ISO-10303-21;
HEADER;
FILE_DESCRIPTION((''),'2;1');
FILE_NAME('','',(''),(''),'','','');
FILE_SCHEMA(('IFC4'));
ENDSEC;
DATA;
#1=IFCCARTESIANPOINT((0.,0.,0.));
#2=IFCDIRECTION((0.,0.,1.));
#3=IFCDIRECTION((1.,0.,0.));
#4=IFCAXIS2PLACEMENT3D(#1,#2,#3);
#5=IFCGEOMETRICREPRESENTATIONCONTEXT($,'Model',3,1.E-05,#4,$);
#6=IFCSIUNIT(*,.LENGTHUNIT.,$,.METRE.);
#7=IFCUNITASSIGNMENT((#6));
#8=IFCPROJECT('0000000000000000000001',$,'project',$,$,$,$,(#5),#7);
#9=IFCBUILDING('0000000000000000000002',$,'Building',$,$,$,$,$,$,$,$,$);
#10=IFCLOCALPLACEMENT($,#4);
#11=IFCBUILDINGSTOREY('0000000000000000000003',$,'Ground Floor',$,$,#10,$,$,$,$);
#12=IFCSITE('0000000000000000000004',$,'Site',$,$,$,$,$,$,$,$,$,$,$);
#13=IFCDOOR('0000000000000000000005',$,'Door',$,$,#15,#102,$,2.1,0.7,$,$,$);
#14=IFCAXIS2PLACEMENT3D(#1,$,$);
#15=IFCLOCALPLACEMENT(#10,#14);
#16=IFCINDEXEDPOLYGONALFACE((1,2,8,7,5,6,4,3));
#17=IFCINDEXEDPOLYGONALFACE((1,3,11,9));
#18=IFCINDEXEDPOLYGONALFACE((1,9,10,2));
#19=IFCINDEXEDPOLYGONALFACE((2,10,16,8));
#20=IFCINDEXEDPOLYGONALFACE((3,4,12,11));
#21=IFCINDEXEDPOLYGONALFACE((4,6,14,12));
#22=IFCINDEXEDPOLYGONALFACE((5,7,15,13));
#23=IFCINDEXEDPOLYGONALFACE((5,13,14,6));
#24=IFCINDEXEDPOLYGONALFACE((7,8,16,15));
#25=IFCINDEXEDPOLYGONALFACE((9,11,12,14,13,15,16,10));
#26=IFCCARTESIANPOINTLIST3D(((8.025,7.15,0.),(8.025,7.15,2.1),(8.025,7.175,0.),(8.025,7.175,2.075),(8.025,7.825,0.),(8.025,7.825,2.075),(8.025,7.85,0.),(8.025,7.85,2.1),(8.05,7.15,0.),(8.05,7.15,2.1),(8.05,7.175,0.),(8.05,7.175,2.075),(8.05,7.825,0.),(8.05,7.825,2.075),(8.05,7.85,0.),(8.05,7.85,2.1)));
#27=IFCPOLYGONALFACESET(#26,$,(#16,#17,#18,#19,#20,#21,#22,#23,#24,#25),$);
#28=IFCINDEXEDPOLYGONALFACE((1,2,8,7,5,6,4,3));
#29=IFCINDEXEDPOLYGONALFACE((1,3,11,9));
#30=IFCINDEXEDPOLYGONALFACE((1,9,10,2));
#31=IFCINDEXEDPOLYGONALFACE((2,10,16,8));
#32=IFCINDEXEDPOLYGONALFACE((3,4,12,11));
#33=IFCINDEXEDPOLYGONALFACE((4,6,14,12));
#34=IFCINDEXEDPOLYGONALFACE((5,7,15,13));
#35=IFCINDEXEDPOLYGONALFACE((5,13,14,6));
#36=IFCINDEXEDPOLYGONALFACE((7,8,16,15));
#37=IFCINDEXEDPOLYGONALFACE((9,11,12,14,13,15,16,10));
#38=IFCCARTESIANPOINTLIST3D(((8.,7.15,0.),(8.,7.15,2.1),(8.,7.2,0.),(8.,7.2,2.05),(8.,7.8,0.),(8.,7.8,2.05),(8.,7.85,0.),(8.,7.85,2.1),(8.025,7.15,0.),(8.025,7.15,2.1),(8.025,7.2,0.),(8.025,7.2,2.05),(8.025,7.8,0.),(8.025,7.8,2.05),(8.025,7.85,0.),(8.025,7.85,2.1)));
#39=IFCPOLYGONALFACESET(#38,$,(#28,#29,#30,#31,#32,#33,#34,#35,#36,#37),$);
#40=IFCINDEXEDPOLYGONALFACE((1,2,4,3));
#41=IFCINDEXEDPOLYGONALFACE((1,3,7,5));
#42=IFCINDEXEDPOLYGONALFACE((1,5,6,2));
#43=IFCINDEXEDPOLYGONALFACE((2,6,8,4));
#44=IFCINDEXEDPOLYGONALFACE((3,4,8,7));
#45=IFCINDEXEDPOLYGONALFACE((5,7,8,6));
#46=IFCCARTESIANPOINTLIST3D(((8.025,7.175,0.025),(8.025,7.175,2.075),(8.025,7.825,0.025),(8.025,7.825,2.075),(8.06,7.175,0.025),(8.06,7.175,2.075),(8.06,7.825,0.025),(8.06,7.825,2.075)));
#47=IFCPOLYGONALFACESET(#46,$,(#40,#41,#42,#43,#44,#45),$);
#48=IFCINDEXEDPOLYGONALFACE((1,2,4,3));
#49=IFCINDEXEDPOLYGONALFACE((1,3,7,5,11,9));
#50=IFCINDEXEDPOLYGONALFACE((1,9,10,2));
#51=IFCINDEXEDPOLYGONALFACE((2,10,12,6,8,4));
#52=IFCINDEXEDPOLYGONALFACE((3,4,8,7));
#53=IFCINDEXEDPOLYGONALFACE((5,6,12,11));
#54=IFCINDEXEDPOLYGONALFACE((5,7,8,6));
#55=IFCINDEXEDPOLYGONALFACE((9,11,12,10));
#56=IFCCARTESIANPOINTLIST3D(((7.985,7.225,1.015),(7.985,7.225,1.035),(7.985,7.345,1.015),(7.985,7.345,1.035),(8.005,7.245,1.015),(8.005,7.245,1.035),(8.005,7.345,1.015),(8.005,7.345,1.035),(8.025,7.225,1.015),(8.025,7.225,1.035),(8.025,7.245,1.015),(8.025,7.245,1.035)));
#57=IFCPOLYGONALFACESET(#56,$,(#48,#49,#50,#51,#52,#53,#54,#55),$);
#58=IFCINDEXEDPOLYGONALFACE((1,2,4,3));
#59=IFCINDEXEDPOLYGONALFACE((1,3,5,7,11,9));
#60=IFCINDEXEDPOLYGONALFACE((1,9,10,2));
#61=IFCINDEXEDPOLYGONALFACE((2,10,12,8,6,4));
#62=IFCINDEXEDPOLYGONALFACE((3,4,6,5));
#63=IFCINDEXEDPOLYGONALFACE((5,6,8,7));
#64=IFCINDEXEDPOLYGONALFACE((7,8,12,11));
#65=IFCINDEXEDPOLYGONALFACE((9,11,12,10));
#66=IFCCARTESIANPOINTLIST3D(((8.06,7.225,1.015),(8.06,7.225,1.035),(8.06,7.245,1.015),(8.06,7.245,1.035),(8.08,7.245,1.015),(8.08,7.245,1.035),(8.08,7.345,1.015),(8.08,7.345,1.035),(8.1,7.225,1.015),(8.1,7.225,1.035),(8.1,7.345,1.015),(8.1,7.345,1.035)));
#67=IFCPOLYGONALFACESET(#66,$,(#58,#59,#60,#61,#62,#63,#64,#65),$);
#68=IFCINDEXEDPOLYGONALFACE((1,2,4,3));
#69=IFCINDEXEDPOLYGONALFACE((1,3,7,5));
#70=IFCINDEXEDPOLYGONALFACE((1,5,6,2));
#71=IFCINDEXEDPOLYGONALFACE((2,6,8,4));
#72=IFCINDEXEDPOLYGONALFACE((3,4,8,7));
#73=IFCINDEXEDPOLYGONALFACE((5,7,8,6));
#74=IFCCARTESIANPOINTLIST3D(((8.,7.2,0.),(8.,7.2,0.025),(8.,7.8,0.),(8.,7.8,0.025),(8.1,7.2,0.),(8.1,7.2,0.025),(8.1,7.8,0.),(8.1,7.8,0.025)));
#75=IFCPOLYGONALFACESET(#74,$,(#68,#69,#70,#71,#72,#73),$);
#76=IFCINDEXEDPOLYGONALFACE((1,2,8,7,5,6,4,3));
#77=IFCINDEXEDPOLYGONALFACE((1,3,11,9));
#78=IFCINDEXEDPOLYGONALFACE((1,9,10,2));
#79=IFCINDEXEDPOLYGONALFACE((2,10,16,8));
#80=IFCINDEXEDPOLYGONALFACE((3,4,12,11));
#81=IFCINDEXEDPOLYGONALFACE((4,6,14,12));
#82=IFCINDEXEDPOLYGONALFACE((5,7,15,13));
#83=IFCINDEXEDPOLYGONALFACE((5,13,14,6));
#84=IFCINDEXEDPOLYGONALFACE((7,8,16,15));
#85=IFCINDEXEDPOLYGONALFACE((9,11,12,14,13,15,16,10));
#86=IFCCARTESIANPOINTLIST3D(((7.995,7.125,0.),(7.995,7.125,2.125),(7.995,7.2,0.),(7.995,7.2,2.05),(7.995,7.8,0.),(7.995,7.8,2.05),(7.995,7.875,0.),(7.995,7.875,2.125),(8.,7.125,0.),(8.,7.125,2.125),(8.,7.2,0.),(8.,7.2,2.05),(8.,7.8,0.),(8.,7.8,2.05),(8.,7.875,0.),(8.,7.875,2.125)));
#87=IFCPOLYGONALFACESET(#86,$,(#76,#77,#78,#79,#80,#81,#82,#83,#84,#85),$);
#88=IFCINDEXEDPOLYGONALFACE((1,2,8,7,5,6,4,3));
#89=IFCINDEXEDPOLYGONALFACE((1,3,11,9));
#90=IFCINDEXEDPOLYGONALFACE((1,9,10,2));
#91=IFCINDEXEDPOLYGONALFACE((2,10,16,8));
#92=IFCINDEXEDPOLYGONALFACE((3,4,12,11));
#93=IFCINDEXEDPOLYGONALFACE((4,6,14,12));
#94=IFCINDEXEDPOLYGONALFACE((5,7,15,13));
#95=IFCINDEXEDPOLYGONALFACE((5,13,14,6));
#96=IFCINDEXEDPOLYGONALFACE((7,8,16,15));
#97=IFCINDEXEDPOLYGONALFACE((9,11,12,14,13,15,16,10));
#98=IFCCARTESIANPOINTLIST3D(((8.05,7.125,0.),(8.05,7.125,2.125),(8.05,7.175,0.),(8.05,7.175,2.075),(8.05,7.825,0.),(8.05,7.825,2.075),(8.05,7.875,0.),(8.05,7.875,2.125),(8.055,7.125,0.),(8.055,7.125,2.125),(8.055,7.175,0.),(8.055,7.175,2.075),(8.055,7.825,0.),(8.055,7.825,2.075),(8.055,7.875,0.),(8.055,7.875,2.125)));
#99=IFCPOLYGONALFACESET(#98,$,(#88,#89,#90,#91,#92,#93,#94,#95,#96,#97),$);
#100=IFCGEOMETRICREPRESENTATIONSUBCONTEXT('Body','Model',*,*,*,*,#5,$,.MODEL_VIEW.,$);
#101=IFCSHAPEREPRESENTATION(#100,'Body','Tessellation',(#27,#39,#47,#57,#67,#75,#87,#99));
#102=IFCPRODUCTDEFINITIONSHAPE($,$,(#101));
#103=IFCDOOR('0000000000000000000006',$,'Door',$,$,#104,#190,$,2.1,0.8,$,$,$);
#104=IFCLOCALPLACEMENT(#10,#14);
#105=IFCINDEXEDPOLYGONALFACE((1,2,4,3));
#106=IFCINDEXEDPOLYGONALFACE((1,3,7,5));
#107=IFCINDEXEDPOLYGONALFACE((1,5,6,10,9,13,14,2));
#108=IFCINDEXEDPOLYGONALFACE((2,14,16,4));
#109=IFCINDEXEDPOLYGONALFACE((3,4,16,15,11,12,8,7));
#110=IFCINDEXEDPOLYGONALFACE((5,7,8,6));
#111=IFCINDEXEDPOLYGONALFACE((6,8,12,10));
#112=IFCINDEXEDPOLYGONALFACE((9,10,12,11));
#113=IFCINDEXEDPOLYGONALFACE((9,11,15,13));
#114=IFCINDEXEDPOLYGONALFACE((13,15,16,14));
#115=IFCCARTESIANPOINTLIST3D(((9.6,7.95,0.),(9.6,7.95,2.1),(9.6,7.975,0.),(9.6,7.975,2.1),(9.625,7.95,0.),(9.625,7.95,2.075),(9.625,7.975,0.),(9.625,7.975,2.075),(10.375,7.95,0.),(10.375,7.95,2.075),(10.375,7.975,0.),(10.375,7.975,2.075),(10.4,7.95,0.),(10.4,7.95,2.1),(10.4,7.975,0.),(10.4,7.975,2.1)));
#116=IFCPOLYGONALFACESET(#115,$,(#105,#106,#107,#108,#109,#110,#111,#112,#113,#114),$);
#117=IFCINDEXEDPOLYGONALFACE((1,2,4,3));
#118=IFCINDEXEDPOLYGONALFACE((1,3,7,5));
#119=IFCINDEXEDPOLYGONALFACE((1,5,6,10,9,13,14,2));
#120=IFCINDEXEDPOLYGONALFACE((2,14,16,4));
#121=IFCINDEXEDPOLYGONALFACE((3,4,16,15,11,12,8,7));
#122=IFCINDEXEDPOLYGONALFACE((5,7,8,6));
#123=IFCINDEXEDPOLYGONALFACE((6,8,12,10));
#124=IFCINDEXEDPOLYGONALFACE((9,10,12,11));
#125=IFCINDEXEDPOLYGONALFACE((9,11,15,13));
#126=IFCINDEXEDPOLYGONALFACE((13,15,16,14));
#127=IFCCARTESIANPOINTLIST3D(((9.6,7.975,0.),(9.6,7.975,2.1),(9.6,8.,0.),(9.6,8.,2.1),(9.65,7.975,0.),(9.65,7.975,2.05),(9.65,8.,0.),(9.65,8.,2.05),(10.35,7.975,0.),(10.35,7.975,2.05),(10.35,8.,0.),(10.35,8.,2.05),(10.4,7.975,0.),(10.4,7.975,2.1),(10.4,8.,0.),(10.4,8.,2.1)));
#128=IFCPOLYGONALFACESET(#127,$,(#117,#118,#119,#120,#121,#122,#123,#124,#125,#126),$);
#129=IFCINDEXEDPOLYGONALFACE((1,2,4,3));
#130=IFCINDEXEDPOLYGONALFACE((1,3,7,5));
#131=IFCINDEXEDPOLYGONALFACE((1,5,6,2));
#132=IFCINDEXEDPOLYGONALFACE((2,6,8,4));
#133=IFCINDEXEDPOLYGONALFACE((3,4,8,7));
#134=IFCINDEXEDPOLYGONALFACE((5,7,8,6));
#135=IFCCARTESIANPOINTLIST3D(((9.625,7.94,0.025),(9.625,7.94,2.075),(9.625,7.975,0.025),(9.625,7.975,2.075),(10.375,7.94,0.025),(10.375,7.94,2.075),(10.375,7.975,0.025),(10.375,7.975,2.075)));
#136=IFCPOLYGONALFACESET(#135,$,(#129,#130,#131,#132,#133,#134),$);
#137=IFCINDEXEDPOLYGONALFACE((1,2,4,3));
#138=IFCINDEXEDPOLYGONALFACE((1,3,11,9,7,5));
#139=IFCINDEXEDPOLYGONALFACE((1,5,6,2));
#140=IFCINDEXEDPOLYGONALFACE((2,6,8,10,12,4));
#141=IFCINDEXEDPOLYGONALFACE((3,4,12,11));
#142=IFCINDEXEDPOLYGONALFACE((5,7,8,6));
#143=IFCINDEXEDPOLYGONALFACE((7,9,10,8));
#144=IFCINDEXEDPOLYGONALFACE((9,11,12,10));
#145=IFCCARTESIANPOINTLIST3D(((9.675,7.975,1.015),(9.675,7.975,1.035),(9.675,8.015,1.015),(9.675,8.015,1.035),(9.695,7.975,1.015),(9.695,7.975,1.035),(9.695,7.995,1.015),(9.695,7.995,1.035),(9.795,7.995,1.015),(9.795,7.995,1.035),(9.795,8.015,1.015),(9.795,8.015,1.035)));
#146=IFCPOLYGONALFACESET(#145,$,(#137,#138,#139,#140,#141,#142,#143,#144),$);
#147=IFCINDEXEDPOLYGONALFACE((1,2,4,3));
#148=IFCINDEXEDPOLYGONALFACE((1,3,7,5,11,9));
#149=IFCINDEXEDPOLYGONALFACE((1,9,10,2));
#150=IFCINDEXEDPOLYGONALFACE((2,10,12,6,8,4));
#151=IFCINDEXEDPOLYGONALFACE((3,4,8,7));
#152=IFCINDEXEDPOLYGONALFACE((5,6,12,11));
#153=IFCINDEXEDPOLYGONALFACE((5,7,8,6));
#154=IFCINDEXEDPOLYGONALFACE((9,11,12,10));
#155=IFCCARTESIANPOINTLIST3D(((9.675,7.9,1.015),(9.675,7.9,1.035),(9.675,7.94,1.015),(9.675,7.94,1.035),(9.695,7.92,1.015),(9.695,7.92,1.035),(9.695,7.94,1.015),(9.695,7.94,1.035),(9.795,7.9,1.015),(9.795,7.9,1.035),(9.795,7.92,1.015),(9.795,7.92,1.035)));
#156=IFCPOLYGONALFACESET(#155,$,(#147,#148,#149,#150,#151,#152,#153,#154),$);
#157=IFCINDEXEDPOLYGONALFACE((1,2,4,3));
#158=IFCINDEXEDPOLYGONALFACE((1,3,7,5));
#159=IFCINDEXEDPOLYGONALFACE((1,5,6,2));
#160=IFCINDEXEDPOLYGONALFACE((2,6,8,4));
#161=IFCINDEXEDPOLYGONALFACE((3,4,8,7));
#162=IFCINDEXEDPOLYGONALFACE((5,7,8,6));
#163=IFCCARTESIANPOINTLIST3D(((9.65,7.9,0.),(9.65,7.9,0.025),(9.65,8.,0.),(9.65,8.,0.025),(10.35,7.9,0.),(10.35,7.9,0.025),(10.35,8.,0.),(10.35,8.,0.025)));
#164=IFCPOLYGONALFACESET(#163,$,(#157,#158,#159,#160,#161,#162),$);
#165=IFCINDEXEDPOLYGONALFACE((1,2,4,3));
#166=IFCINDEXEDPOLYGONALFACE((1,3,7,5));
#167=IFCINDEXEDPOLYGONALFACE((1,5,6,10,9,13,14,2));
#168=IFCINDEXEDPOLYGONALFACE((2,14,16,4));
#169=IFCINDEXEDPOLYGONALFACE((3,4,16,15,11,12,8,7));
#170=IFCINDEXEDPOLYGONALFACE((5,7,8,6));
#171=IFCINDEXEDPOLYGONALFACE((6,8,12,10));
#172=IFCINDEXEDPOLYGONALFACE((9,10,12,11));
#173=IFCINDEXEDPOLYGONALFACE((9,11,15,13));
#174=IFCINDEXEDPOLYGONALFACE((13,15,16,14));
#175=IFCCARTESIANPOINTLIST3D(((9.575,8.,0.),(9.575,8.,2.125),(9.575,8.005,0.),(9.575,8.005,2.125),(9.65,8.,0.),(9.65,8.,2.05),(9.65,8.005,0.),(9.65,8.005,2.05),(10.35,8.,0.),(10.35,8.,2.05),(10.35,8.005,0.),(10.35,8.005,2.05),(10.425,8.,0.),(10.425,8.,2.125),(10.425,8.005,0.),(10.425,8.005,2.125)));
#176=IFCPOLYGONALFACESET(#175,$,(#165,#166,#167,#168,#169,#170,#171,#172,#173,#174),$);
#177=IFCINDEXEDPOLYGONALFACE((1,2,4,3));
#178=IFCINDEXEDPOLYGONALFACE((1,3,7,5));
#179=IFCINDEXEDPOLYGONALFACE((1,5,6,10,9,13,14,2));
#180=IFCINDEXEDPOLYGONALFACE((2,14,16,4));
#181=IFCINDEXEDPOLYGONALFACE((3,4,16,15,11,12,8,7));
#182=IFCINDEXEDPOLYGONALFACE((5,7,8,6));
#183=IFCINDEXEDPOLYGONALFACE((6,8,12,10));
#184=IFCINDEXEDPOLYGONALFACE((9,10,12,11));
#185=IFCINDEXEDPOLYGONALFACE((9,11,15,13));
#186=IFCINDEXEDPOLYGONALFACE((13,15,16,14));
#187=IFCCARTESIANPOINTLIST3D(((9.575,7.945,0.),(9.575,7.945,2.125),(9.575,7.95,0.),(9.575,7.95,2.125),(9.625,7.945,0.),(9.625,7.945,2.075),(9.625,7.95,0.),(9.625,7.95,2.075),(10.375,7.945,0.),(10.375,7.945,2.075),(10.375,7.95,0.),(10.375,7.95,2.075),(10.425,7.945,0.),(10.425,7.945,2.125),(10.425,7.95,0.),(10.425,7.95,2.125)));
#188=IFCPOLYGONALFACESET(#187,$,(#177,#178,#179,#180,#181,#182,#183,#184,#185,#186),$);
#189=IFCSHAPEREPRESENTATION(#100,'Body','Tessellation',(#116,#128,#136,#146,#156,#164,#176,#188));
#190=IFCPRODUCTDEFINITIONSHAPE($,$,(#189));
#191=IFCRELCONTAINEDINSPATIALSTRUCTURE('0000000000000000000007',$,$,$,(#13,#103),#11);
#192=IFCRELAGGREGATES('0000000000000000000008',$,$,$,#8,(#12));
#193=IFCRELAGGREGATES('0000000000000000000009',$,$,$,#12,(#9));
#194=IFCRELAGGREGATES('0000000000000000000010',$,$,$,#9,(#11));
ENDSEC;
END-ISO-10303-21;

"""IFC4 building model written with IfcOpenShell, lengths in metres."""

from ifc_helpers import new_model, si_unit, frame, origin_with_axes, place, context, subcontext, project, spatial, line, indexed_curve, outline, extrude, element, save


model = new_model("IFC4")

# Units and contexts
model_context = context("Model", 3, precision=1e-05, world=origin_with_axes())
body_context = subcontext(model_context, "Body", "Model", "MODEL_VIEW")
ifc_project = project(units=[si_unit("LENGTHUNIT", "METRE")], contexts=[model_context])

# Site, building, storey
site = spatial("IfcSite", under=ifc_project, Name="Site")
building = spatial("IfcBuilding", under=site, Name="Building")
storey_placement = place(None, origin_with_axes())
storey = spatial("IfcBuildingStorey", under=building, at=storey_placement, Name="Ground Floor")

# Doors
door_1_placement = place(storey_placement, frame((8.0, 7.85, 0.0), z_axis=(0.0, 0.0, 1.0), x_axis=(0.0, -1.0, 0.0)))
element("IfcDoor", 1, at=door_1_placement, inside=storey, Name="Door", OverallHeight=2.1, OverallWidth=0.7, context=body_context, shape_type="SweptSolid", body=[
    extrude(outline(indexed_curve([(0.0, 0.0), (0.0, 2.1), (0.7, 2.1), (0.7, 0.0), (0.675, 0.0), (0.675, 2.075), (0.025, 2.075), (0.025, 0.0)], segments=[line(1, 2, 3, 4, 5, 6, 7, 8, 1)])), frame((0.0, 0.025, 0.0), z_axis=(0.0, -1.0, 0.0), x_axis=(1.0, 0.0, 0.0)), (0.0, 0.0, -1.0), 0.025),
    extrude(outline(indexed_curve([(0.0, 0.0), (0.0, 2.1), (0.7, 2.1), (0.7, 0.0), (0.65, 0.0), (0.65, 2.05), (0.05, 2.05), (0.05, 0.0)], segments=[line(1, 2, 3, 4, 5, 6, 7, 8, 1)])), frame((0.0, 0.0, 0.0), z_axis=(0.0, -1.0, 0.0), x_axis=(1.0, 0.0, 0.0)), (0.0, 0.0, -1.0), 0.025),
    extrude(outline(indexed_curve([(0.0, 0.0), (0.65, 0.0), (0.65, 0.035), (0.0, 0.035)], segments=[line(1, 2, 3, 4, 1)])), frame((0.025, 0.025, 0.025), z_axis=(0.0, 0.0, 1.0), x_axis=(1.0, 0.0, 0.0)), (0.0, 0.0, 1.0), 2.05),
    extrude(outline(indexed_curve([(0.0, 0.0), (0.0, -0.04), (-0.12, -0.04), (-0.12, -0.02), (-0.02, -0.02), (-0.02, 0.0)], segments=[line(1, 2, 3, 4, 5, 6, 1)])), frame((0.625, 0.025, 1.015), z_axis=(0.0, 0.0, 1.0), x_axis=(1.0, 0.0, 0.0)), (0.0, 0.0, 1.0), 0.02),
    extrude(outline(indexed_curve([(0.0, 0.0), (0.0, 0.04), (-0.12, 0.04), (-0.12, 0.02), (-0.02, 0.02), (-0.02, 0.0)], segments=[line(1, 2, 3, 4, 5, 6, 1)])), frame((0.625, 0.06, 1.015), z_axis=(0.0, 0.0, 1.0), x_axis=(1.0, 0.0, 0.0)), (0.0, 0.0, 1.0), 0.02),
    extrude(outline(indexed_curve([(0.0, 0.0), (0.6, 0.0), (0.6, 0.1), (0.0, 0.1)], segments=[line(1, 2, 3, 4, 1)])), frame((0.05, 0.0, 0.0), z_axis=(0.0, 0.0, 1.0), x_axis=(1.0, 0.0, 0.0)), (0.0, 0.0, 1.0), 0.025),
    extrude(outline(indexed_curve([(0.0, 0.0), (0.0, 2.125), (0.75, 2.125), (0.75, 0.0), (0.675, 0.0), (0.675, 2.05), (0.075, 2.05), (0.075, 0.0)], segments=[line(1, 2, 3, 4, 5, 6, 7, 8, 1)])), frame((-0.025, -0.005, 0.0), z_axis=(0.0, -1.0, 0.0), x_axis=(1.0, 0.0, 0.0)), (0.0, 0.0, -1.0), 0.005),
    extrude(outline(indexed_curve([(0.0, 0.0), (0.0, 2.125), (0.75, 2.125), (0.75, 0.0), (0.7, 0.0), (0.7, 2.075), (0.05, 2.075), (0.05, 0.0)], segments=[line(1, 2, 3, 4, 5, 6, 7, 8, 1)])), frame((-0.025, 0.05, 0.0), z_axis=(0.0, -1.0, 0.0), x_axis=(1.0, 0.0, 0.0)), (0.0, 0.0, -1.0), 0.005),
])
door_2_placement = place(storey_placement, frame((10.4, 8.0, 0.0), z_axis=(0.0, 0.0, 1.0), x_axis=(-1.0, 0.0, 0.0)))
element("IfcDoor", 2, at=door_2_placement, inside=storey, Name="Door", OverallHeight=2.1, OverallWidth=0.8, context=body_context, shape_type="SweptSolid", body=[
    extrude(outline(indexed_curve([(0.0, 0.0), (0.0, 2.1), (0.8, 2.1), (0.8, 0.0), (0.775, 0.0), (0.775, 2.075), (0.025, 2.075), (0.025, 0.0)], segments=[line(1, 2, 3, 4, 5, 6, 7, 8, 1)])), frame((0.0, 0.025, 0.0), z_axis=(0.0, -1.0, 0.0), x_axis=(1.0, 0.0, 0.0)), (0.0, 0.0, -1.0), 0.025),
    extrude(outline(indexed_curve([(0.0, 0.0), (0.0, 2.1), (0.8, 2.1), (0.8, 0.0), (0.75, 0.0), (0.75, 2.05), (0.05, 2.05), (0.05, 0.0)], segments=[line(1, 2, 3, 4, 5, 6, 7, 8, 1)])), frame((0.0, 0.0, 0.0), z_axis=(0.0, -1.0, 0.0), x_axis=(1.0, 0.0, 0.0)), (0.0, 0.0, -1.0), 0.025),
    extrude(outline(indexed_curve([(0.0, 0.0), (0.75, 0.0), (0.75, 0.035), (0.0, 0.035)], segments=[line(1, 2, 3, 4, 1)])), frame((0.025, 0.025, 0.025), z_axis=(0.0, 0.0, 1.0), x_axis=(1.0, 0.0, 0.0)), (0.0, 0.0, 1.0), 2.05),
    extrude(outline(indexed_curve([(0.0, 0.0), (0.0, -0.04), (-0.12, -0.04), (-0.12, -0.02), (-0.02, -0.02), (-0.02, 0.0)], segments=[line(1, 2, 3, 4, 5, 6, 1)])), frame((0.725, 0.025, 1.015), z_axis=(0.0, 0.0, 1.0), x_axis=(1.0, 0.0, 0.0)), (0.0, 0.0, 1.0), 0.02),
    extrude(outline(indexed_curve([(0.0, 0.0), (0.0, 0.04), (-0.12, 0.04), (-0.12, 0.02), (-0.02, 0.02), (-0.02, 0.0)], segments=[line(1, 2, 3, 4, 5, 6, 1)])), frame((0.725, 0.06, 1.015), z_axis=(0.0, 0.0, 1.0), x_axis=(1.0, 0.0, 0.0)), (0.0, 0.0, 1.0), 0.02),
    extrude(outline(indexed_curve([(0.0, 0.0), (0.7, 0.0), (0.7, 0.1), (0.0, 0.1)], segments=[line(1, 2, 3, 4, 1)])), frame((0.05, 0.0, 0.0), z_axis=(0.0, 0.0, 1.0), x_axis=(1.0, 0.0, 0.0)), (0.0, 0.0, 1.0), 0.025),
    extrude(outline(indexed_curve([(0.0, 0.0), (0.0, 2.125), (0.85, 2.125), (0.85, 0.0), (0.775, 0.0), (0.775, 2.05), (0.075, 2.05), (0.075, 0.0)], segments=[line(1, 2, 3, 4, 5, 6, 7, 8, 1)])), frame((-0.025, -0.005, 0.0), z_axis=(0.0, -1.0, 0.0), x_axis=(1.0, 0.0, 0.0)), (0.0, 0.0, -1.0), 0.005),
    extrude(outline(indexed_curve([(0.0, 0.0), (0.0, 2.125), (0.85, 2.125), (0.85, 0.0), (0.8, 0.0), (0.8, 2.075), (0.05, 2.075), (0.05, 0.0)], segments=[line(1, 2, 3, 4, 5, 6, 7, 8, 1)])), frame((-0.025, 0.05, 0.0), z_axis=(0.0, -1.0, 0.0), x_axis=(1.0, 0.0, 0.0)), (0.0, 0.0, -1.0), 0.005),
])

save(model, "model.ifc")
